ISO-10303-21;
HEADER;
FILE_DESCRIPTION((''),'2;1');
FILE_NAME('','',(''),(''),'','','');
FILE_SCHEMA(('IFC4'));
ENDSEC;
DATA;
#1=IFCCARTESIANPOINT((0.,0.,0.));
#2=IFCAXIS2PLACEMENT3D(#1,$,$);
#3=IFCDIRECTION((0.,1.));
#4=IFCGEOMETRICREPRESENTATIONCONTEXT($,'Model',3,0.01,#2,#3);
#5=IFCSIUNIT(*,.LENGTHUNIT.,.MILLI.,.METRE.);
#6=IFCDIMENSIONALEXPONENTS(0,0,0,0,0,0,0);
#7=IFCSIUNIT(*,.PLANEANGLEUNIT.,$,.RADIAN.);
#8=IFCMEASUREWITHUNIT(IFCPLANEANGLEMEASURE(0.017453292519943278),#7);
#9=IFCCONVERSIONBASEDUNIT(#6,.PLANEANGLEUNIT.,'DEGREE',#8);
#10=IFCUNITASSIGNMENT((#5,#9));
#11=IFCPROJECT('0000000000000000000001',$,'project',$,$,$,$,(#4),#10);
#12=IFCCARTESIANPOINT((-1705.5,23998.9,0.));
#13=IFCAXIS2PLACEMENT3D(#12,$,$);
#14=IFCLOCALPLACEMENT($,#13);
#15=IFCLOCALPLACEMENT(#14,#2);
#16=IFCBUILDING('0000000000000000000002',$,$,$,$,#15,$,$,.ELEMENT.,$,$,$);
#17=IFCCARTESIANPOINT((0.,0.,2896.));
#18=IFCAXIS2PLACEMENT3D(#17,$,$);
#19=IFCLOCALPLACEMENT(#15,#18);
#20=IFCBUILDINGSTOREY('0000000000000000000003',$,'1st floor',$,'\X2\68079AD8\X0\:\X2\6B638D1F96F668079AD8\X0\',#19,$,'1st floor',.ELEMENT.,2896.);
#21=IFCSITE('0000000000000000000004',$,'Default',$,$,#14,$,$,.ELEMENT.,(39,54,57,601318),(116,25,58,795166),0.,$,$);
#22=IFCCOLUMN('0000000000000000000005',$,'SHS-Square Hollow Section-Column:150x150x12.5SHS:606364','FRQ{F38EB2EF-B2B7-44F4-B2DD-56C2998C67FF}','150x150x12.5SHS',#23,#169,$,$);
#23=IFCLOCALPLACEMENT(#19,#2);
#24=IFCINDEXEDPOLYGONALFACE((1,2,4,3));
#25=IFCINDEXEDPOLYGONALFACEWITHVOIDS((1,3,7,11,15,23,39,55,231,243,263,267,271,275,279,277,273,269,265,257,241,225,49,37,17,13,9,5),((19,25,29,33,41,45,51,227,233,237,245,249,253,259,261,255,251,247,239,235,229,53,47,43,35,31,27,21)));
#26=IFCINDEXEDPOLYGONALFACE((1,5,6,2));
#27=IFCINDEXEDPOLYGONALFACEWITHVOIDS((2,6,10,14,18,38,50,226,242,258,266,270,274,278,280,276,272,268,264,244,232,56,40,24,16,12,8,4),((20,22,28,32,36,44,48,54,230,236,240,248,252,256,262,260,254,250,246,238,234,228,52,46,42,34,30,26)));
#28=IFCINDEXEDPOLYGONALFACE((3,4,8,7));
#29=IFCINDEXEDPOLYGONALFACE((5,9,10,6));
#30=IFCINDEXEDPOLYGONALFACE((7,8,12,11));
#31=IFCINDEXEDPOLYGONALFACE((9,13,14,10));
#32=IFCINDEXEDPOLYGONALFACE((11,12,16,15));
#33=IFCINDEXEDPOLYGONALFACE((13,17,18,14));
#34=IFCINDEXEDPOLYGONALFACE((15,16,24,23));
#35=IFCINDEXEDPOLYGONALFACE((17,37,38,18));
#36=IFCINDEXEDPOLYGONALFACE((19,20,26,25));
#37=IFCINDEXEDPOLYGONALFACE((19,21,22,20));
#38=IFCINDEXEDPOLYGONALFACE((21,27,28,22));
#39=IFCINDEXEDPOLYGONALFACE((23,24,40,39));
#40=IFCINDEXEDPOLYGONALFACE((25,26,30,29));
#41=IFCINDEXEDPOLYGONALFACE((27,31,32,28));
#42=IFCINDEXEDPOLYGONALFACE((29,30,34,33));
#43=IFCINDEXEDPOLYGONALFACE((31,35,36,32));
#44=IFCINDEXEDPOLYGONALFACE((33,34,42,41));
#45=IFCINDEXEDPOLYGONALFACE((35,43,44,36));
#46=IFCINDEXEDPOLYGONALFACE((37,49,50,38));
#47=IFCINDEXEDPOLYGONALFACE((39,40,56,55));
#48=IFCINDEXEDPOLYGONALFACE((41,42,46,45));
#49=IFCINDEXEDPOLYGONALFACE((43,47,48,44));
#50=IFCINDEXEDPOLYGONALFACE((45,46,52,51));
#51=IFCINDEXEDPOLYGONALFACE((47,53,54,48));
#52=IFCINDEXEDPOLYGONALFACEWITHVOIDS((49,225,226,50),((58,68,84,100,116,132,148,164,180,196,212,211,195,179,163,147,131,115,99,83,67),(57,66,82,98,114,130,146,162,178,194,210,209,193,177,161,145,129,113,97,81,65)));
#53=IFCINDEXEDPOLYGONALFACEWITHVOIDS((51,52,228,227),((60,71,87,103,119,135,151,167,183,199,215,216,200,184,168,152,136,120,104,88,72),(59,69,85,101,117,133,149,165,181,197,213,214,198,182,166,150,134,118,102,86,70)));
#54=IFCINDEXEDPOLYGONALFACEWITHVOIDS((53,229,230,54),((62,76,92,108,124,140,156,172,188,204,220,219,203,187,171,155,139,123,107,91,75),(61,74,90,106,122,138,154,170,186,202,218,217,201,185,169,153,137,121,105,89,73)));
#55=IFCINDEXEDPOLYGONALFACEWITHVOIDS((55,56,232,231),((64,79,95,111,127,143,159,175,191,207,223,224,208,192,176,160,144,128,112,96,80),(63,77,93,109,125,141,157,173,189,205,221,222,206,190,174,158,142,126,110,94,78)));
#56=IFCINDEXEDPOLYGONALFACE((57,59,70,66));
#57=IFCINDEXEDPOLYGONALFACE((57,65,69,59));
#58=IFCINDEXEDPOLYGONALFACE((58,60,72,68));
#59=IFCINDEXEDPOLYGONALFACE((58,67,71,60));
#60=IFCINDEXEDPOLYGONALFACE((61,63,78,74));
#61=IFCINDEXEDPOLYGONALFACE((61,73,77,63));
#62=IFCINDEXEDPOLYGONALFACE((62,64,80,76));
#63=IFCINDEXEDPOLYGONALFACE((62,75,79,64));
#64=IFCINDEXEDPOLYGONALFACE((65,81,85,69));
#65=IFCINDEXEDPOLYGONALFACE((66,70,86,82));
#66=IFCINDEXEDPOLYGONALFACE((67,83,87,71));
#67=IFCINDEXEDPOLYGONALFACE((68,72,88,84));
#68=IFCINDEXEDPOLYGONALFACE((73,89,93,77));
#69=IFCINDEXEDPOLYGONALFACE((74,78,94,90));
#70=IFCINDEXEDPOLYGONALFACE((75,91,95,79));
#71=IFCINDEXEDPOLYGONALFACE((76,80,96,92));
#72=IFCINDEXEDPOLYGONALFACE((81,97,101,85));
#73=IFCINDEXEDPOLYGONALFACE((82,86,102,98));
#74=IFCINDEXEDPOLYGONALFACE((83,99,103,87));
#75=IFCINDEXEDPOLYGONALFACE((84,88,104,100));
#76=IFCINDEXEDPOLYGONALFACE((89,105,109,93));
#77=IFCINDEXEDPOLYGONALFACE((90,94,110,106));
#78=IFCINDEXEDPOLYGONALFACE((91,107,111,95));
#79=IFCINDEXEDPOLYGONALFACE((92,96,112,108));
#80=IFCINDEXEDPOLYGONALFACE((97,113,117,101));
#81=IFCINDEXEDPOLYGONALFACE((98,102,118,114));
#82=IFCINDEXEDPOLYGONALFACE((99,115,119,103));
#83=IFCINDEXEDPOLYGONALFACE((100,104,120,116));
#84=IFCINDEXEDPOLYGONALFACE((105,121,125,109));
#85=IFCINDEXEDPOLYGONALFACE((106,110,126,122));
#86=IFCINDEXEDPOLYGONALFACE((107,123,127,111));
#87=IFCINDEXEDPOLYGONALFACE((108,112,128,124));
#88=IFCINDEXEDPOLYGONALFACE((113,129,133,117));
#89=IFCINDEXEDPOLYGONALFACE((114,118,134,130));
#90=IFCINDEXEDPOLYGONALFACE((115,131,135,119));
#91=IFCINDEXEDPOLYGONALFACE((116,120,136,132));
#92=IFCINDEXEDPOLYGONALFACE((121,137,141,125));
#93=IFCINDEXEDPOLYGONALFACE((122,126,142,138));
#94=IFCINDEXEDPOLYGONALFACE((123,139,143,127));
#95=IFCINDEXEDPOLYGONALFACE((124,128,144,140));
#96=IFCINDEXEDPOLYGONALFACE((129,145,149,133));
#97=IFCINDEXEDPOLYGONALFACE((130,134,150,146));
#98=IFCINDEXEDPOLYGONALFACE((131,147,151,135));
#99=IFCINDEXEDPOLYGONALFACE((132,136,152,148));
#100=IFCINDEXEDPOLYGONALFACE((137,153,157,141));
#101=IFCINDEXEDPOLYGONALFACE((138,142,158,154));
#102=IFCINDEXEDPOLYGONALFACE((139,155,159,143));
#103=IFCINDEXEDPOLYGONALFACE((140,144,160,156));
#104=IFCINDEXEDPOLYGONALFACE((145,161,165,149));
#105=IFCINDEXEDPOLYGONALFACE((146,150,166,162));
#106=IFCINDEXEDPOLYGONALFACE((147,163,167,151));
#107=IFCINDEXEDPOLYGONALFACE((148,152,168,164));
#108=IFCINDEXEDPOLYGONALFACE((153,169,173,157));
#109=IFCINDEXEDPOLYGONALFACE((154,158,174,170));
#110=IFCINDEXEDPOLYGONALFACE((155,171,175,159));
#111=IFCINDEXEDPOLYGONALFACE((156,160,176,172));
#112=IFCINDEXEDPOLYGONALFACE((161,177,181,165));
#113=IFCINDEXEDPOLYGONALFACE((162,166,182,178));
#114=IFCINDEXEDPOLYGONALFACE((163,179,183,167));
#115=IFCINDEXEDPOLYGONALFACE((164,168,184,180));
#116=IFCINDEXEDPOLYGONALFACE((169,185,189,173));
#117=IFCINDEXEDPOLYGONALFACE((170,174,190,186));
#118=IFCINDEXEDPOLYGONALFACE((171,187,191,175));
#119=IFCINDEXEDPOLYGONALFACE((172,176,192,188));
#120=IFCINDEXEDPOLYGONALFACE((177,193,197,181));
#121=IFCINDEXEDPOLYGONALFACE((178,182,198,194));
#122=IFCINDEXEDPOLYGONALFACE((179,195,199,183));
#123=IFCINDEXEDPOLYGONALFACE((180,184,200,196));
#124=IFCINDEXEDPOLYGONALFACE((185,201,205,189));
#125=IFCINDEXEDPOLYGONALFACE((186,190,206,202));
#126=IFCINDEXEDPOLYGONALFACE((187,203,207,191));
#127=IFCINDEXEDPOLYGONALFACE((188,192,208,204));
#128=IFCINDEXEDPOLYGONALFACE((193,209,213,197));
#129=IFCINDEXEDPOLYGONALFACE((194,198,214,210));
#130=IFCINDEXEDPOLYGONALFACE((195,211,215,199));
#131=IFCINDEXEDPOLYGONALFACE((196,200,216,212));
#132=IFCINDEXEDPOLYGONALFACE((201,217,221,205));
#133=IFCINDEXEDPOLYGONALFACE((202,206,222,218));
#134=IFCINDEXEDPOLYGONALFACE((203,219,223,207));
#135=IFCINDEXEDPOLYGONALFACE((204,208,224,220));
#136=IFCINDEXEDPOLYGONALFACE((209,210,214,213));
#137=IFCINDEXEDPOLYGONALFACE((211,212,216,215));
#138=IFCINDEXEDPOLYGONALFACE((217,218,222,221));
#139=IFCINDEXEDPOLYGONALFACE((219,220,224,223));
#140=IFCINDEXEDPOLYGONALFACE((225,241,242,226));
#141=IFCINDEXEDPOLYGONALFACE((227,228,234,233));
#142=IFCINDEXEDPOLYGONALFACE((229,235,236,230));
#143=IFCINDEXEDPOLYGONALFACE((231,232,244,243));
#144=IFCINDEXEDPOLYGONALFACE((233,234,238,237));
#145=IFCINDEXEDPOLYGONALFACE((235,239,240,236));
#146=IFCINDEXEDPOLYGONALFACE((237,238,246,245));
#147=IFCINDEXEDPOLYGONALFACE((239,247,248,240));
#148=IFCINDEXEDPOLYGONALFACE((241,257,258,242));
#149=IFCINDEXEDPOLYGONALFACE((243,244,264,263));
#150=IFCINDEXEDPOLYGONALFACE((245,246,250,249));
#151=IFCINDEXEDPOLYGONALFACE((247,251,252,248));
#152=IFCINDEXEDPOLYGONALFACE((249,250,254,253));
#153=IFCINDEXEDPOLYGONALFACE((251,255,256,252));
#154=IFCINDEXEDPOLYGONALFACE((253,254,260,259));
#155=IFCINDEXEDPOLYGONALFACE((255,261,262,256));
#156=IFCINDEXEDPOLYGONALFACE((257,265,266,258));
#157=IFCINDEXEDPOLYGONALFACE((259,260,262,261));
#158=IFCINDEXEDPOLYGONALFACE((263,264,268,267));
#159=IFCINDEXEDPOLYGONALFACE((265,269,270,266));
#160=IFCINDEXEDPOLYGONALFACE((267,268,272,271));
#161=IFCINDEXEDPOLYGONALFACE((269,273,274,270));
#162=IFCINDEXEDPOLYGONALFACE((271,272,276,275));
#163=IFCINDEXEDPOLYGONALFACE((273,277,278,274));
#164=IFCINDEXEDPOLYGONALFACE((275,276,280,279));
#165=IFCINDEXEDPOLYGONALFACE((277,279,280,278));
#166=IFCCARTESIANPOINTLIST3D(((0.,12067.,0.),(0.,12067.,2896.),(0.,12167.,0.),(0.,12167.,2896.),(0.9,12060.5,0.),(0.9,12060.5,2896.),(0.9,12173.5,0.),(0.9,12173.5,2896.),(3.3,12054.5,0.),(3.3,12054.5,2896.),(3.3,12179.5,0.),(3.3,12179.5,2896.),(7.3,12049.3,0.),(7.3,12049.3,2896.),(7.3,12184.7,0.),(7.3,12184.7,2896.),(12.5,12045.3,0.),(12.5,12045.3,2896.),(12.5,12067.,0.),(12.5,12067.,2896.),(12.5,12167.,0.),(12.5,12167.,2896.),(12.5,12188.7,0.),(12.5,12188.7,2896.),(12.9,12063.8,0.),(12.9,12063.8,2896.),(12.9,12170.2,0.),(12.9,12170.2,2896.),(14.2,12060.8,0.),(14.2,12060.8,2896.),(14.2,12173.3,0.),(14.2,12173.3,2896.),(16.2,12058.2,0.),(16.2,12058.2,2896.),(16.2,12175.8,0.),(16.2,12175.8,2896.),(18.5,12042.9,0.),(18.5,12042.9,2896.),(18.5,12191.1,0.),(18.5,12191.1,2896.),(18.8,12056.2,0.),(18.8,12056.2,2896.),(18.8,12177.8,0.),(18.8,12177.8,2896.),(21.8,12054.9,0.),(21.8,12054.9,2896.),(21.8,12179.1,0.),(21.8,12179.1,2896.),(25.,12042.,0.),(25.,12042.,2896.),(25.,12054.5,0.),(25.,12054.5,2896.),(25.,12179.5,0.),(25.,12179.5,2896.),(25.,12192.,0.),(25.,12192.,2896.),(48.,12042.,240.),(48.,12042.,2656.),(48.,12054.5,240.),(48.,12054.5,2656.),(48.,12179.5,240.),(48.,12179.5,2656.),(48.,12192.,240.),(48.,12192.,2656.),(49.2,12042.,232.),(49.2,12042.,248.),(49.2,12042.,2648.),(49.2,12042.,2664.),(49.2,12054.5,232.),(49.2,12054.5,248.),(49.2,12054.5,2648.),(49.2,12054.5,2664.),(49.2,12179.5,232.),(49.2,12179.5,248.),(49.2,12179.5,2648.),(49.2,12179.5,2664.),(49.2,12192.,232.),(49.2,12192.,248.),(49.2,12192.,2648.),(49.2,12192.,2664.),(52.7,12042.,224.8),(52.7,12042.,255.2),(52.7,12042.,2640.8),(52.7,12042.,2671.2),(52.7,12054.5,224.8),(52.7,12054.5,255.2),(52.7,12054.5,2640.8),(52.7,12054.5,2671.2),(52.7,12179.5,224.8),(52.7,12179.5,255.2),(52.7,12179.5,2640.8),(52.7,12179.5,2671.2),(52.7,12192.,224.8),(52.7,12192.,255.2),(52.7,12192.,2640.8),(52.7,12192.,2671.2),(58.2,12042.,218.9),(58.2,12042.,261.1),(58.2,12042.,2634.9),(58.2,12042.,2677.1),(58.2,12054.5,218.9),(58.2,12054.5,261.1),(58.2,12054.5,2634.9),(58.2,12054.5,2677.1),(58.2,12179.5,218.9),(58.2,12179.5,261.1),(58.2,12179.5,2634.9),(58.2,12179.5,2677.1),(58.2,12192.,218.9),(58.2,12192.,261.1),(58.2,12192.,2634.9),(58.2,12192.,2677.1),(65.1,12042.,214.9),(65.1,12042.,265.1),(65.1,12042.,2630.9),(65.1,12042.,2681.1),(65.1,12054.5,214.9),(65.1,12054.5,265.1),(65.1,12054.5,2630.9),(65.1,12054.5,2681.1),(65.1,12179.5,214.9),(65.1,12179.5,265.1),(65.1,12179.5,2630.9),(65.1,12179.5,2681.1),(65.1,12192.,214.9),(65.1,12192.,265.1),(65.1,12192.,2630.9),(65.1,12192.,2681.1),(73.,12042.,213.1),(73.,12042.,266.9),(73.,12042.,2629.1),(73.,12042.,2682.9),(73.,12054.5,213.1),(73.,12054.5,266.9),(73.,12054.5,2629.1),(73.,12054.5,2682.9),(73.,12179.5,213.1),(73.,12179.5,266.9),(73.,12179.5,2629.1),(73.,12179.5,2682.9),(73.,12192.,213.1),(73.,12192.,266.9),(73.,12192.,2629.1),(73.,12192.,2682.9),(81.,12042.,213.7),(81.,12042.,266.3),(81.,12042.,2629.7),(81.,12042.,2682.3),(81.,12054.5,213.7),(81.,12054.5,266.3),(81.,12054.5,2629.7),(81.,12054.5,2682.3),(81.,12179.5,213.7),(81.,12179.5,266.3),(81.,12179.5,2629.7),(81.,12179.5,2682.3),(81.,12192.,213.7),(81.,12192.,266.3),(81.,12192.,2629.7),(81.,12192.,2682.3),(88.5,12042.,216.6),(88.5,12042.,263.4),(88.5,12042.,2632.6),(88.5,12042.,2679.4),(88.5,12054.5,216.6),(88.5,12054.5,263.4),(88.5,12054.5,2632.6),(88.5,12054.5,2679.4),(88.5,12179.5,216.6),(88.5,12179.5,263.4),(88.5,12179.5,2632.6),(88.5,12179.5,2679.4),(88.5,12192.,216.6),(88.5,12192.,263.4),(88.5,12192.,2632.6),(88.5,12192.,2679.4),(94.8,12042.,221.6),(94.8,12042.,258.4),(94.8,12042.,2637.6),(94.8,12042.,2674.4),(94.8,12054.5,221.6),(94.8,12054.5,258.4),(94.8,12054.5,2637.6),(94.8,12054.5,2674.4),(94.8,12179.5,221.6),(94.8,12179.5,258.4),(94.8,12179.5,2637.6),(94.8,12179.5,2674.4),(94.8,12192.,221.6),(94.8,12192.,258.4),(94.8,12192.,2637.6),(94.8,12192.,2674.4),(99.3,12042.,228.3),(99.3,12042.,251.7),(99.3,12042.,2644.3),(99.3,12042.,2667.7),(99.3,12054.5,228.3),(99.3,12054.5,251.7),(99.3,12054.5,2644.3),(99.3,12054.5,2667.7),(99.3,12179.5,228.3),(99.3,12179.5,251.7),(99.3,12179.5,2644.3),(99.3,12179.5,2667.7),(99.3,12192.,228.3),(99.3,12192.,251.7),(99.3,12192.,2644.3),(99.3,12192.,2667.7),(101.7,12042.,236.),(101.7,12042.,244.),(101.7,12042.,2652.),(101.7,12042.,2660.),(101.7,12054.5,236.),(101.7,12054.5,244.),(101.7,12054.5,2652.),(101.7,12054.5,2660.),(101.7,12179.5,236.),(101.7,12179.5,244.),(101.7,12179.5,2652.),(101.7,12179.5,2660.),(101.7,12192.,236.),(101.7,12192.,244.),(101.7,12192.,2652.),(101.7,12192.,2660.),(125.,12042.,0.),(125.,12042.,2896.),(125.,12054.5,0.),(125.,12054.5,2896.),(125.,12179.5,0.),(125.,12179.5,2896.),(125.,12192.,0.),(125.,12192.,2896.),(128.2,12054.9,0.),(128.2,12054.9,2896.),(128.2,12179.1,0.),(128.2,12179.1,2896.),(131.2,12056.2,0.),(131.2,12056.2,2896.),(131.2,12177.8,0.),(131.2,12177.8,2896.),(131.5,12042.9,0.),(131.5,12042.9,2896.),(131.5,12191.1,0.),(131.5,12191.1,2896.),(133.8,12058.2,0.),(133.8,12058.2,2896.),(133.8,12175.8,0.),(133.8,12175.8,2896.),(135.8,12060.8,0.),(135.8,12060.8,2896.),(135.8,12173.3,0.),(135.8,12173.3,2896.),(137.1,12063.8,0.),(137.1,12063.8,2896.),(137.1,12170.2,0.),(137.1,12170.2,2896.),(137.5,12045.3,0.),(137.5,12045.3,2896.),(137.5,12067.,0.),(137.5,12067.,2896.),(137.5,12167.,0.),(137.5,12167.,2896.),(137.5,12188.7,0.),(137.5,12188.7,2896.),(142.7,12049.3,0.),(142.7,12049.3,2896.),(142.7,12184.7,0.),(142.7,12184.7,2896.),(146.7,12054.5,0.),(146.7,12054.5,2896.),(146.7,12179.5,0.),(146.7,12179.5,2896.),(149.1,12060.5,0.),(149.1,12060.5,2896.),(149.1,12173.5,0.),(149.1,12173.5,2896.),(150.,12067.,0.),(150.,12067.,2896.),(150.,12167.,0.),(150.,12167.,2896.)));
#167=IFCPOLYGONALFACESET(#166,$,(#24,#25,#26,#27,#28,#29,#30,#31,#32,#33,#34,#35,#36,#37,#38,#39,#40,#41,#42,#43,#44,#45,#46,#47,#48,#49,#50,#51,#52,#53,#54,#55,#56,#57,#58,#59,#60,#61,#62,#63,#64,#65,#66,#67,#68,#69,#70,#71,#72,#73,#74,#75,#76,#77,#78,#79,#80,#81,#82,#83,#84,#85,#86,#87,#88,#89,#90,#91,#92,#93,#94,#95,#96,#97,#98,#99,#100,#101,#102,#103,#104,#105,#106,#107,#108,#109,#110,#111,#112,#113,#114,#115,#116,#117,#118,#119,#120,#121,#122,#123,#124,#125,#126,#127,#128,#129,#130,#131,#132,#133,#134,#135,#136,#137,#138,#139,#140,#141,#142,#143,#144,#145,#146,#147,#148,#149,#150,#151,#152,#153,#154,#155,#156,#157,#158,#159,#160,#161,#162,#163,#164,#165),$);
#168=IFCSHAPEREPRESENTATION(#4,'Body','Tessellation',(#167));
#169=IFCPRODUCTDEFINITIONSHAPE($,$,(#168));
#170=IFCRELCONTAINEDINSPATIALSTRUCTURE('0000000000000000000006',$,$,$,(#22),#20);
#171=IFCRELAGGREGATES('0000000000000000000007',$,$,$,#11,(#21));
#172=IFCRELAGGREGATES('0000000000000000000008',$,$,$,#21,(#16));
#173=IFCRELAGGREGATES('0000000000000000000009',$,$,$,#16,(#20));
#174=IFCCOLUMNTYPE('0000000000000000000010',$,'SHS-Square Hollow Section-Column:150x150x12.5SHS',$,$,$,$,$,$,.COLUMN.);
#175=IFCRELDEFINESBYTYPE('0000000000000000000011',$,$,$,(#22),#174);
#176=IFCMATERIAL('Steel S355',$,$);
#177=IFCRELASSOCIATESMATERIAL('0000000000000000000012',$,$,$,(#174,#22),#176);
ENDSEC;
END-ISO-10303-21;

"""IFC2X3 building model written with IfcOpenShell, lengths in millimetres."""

from ifc_helpers import new_model, entity, si_unit, converted_unit, direction, frame, frame_2d, origin, origin_2d, place, context, project, spatial, circle_curve, hollow_rectangle, outline, extrude, material, type_object, element, save


model = new_model("IFC2X3")

# Units and contexts
model_context = context("Model", 3, precision=0.01, world=origin(), true_north=direction((0.0, 1.0)))
ifc_project = project(units=[si_unit("LENGTHUNIT", "METRE", prefix="MILLI"), converted_unit("PLANEANGLEUNIT", "DEGREE", entity("IfcPlaneAngleMeasure", 0.017453292519943278), si_unit("PLANEANGLEUNIT", "RADIAN"), dimensions=[0, 0, 0, 0, 0, 0, 0])], contexts=[model_context])

# Site, building, storey
site_placement = place(None, frame((-1705.5, 23998.9, 0.0)))
site = spatial("IfcSite", under=ifc_project, at=site_placement, Name="Default", CompositionType="ELEMENT", RefLatitude=(39, 54, 57, 601318), RefLongitude=(116, 25, 58, 795166), RefElevation=0.0)
building_placement = place(site_placement, origin())
building = spatial("IfcBuilding", under=site, at=building_placement, CompositionType="ELEMENT")
storey_placement = place(building_placement, frame((0.0, 0.0, 2896.0)))
storey = spatial("IfcBuildingStorey", under=building, at=storey_placement, Name="1st floor", ObjectType="标高:正负零标高", LongName="1st floor", CompositionType="ELEMENT", Elevation=2896.0)

# Column, openings
ifc_material_1 = material(Name="Steel S355")
column_type_1 = type_object("IfcColumnType", Name="SHS-Square Hollow Section-Column:150x150x12.5SHS", PredefinedType="COLUMN", material=ifc_material_1)
column_1_placement = place(storey_placement, frame((75.0, 12117.0, 2896.0), z_axis=(0.0, 0.0, 1.0), x_axis=(0.0, -1.0, 0.0)))
column_1 = element("IfcColumn", 1, at=column_1_placement, inside=storey, type_object=column_type_1, material=ifc_material_1, Name="SHS-Square Hollow Section-Column:150x150x12.5SHS:606364", Description="FRQ{F38EB2EF-B2B7-44F4-B2DD-56C2998C67FF}", ObjectType="150x150x12.5SHS", context=model_context, shape_type="SweptSolid", body=[
    extrude(hollow_rectangle(XDim=150.0, YDim=150.0, WallThickness=12.5, InnerFilletRadius=12.5, OuterFilletRadius=25.0, at=origin_2d()), origin(), (0.0, 0.0, -1.0), 2896.0),
])
opening_1_placement = place(column_1_placement, frame((175.1, 0.0, -2896.0), z_axis=(-1.0, 0.0, 0.0), x_axis=(0.0, -1.0, 0.0)))
element("IfcOpeningElement", 2, at=opening_1_placement, cuts=column_1, ObjectType="Opening", context=model_context, shape_type="SweptSolid", body=[
    extrude(outline(circle_curve(frame_2d((0.0, 240.0), x_axis=(1.0, 0.0)), 27.0)), origin(), (0.0, 0.0, 1.0), 350.2),
])
opening_2_placement = place(column_1_placement, frame((175.1, 0.0, 0.0), z_axis=(-1.0, 0.0, 0.0), x_axis=(0.0, -1.0, 0.0)))
element("IfcOpeningElement", 3, at=opening_2_placement, cuts=column_1, ObjectType="Opening", context=model_context, shape_type="SweptSolid", body=[
    extrude(outline(circle_curve(frame_2d((0.0, -240.0), x_axis=(1.0, 0.0)), 27.0)), origin(), (0.0, 0.0, 1.0), 350.2),
])

save(model, "model.ifc")
